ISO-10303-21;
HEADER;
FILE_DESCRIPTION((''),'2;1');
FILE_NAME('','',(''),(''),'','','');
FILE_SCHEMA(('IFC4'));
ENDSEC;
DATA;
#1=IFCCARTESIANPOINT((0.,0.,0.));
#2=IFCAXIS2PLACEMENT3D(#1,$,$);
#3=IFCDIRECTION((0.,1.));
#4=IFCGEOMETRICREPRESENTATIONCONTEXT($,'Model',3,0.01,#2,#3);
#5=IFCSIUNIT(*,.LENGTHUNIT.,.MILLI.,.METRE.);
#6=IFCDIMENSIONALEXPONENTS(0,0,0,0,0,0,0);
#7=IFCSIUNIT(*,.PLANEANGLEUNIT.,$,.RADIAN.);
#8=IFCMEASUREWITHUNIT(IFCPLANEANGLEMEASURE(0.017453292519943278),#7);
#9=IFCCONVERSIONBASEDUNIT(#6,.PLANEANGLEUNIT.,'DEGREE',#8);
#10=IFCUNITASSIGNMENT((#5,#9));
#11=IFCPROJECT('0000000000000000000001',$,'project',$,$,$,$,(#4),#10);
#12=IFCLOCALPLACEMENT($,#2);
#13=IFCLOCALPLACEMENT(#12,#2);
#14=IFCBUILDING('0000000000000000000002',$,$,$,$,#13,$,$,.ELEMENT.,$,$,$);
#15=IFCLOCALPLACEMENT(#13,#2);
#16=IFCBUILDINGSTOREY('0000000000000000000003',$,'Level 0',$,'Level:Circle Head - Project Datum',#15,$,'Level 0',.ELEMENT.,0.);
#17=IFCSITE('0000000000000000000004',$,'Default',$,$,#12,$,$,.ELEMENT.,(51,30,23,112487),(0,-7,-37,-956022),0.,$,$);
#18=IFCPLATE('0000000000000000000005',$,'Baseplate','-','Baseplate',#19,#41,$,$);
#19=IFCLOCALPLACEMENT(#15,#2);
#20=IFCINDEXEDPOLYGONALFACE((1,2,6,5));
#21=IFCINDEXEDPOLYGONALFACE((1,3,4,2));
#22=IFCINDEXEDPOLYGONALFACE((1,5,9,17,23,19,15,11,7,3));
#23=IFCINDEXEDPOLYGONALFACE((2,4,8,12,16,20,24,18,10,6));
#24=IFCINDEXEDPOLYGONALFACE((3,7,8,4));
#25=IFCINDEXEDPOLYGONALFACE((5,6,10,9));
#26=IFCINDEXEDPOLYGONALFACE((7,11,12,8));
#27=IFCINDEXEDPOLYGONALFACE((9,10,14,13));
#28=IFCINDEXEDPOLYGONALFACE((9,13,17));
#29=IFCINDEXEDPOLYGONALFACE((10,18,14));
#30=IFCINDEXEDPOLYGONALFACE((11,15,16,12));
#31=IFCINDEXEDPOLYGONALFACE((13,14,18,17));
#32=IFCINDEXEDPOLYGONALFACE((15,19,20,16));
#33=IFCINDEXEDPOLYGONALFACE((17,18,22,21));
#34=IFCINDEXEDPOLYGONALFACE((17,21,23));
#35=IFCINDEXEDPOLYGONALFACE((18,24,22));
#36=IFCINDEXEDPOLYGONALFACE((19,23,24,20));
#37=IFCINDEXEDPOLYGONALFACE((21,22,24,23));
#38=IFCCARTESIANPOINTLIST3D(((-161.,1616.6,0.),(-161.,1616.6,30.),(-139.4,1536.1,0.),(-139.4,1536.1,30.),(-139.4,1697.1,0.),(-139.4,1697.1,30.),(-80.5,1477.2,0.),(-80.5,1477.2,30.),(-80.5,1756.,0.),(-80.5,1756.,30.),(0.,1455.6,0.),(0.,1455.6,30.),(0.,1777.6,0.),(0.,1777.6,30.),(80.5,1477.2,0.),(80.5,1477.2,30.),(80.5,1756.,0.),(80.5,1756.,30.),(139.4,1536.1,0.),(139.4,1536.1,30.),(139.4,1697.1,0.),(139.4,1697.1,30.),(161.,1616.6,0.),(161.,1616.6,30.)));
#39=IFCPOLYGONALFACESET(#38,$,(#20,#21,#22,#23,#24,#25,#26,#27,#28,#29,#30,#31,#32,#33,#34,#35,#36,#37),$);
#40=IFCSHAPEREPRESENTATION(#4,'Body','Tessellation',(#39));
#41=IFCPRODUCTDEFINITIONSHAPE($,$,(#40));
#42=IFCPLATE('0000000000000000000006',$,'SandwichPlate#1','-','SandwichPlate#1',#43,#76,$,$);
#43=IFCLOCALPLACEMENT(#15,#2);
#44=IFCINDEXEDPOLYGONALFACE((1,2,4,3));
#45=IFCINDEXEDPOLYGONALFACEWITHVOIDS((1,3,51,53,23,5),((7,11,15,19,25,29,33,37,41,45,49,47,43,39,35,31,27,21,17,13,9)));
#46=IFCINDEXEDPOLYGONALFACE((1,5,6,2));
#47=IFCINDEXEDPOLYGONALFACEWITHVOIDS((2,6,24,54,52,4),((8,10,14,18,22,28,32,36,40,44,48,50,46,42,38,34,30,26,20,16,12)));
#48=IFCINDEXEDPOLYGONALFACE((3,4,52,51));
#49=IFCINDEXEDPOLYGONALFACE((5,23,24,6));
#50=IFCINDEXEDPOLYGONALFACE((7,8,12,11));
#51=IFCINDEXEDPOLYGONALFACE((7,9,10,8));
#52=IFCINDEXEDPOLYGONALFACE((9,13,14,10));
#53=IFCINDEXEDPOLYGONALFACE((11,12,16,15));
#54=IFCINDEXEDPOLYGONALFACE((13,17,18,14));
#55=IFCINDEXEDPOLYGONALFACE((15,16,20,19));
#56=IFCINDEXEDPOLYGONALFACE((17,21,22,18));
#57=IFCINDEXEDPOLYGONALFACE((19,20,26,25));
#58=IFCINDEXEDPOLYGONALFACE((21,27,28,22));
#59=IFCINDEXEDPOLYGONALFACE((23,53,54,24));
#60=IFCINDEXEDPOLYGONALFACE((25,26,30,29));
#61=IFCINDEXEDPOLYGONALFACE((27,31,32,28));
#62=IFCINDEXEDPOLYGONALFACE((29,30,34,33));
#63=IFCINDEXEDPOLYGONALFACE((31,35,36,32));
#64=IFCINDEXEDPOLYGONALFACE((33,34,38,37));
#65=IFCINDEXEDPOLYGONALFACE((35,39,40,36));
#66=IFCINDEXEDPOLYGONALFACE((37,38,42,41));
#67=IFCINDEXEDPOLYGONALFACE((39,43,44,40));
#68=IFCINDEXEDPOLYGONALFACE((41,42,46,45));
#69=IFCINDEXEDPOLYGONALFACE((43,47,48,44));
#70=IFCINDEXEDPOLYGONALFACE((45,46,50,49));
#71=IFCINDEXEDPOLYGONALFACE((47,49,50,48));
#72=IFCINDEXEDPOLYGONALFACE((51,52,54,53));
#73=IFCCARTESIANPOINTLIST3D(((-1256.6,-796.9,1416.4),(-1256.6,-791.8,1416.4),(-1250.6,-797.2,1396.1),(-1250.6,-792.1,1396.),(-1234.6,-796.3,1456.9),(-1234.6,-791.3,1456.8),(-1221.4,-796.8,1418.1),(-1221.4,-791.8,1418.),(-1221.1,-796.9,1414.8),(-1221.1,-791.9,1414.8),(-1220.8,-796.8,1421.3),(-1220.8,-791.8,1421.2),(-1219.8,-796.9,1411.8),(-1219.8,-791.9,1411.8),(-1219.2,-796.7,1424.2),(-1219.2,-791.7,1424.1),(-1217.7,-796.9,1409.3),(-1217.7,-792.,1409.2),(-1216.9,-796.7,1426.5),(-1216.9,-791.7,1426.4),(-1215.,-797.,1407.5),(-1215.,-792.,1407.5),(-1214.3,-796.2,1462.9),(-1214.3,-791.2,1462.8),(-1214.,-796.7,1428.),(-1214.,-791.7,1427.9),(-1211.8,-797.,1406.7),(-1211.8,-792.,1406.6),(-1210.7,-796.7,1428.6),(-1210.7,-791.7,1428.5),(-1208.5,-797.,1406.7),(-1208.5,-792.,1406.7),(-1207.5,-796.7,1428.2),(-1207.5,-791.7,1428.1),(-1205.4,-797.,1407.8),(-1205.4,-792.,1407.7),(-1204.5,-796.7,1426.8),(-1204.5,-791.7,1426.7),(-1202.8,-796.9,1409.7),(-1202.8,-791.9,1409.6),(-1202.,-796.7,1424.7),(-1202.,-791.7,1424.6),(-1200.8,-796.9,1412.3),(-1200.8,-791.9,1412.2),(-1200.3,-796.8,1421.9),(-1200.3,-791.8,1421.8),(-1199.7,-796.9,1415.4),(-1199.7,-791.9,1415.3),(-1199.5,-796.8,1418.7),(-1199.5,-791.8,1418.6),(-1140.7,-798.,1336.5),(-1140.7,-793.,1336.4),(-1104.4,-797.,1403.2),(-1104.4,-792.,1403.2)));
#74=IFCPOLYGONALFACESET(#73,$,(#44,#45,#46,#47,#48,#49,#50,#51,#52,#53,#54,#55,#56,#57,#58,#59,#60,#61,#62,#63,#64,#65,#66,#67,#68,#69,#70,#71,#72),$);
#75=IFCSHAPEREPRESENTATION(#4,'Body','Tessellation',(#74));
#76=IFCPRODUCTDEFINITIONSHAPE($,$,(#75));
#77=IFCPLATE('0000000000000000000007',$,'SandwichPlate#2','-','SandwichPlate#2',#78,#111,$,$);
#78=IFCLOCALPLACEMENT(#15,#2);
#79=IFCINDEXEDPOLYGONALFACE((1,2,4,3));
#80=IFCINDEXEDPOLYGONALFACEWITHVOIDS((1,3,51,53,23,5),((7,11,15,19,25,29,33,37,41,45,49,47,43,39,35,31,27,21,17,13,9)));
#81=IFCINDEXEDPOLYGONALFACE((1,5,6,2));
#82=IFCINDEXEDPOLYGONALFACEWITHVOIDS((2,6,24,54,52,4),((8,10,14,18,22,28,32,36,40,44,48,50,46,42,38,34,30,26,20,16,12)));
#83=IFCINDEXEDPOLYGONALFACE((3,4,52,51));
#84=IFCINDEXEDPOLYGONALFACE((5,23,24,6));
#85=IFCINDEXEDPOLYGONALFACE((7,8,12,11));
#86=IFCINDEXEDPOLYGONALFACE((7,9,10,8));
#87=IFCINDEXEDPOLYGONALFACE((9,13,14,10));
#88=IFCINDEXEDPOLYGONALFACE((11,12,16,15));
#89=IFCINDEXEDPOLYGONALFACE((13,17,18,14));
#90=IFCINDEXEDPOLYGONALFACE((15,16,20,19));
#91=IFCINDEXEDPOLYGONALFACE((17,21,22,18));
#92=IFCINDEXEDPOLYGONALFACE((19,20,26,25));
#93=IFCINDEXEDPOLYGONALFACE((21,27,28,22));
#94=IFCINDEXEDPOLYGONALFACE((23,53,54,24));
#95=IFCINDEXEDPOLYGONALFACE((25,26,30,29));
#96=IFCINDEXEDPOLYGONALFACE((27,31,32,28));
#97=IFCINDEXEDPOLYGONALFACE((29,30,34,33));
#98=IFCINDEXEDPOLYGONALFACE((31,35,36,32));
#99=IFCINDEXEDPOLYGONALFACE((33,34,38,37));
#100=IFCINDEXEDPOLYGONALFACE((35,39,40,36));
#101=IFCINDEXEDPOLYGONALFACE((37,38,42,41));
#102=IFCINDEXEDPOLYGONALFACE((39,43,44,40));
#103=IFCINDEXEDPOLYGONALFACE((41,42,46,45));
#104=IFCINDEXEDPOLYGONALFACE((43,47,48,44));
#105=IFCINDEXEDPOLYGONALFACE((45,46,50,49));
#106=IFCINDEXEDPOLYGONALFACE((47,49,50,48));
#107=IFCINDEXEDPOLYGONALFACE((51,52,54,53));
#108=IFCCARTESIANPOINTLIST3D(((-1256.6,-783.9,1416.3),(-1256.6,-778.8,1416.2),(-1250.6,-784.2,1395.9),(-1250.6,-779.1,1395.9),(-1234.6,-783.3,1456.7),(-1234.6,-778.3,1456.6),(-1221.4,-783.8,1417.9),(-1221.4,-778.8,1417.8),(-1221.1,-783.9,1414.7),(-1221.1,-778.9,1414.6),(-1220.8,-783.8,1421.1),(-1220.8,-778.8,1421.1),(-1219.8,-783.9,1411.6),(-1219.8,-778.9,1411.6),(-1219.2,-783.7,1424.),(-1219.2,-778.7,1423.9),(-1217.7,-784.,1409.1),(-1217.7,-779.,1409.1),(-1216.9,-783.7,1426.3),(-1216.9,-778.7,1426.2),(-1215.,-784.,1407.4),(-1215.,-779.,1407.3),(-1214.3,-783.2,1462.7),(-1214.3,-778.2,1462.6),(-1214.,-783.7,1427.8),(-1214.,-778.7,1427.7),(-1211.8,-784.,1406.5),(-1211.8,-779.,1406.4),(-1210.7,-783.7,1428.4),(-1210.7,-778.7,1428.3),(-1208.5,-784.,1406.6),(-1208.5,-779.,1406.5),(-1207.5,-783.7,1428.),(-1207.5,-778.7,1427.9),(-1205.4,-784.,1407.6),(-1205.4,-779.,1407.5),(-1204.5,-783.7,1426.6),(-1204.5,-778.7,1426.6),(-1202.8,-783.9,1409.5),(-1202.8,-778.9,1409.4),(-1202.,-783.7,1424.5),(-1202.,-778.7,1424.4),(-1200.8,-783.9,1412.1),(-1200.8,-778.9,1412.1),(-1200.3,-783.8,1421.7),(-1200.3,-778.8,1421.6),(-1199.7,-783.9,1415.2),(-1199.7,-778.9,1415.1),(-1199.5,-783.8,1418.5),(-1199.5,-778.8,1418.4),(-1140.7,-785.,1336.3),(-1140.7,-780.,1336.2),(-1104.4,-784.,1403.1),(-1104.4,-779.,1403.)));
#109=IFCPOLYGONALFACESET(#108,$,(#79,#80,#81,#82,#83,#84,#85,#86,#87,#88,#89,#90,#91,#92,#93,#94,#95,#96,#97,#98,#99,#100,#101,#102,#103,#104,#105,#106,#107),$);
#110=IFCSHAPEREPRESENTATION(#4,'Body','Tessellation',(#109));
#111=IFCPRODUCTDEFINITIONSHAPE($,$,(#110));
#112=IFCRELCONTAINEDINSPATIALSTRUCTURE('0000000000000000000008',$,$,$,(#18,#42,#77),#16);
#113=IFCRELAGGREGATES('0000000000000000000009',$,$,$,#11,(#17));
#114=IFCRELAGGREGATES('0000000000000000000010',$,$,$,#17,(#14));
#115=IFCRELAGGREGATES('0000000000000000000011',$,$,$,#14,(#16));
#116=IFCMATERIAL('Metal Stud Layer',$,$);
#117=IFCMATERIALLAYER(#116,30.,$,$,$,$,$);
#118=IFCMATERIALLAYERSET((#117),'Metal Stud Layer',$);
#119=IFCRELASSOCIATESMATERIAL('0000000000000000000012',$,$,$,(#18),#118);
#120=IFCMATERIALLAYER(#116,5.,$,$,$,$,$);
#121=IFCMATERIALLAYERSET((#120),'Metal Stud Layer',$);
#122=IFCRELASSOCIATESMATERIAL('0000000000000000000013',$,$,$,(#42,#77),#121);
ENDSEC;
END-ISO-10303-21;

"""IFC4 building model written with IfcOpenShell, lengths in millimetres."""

from ifc_helpers import new_model, entity, si_unit, converted_unit, point, direction, frame, frame_2d, origin, origin_with_axes, origin_2d_with_axis, place, context, project, spatial, polyline, circle_curve, line_curve, trimmed, segment, composite_curve, circle, outline, extrude, material, layer, layer_set, element, save


model = new_model("IFC4")

# Units and contexts
model_context = context("Model", 3, precision=0.01, world=origin(), true_north=direction((0.0, 1.0)))
ifc_project = project(units=[si_unit("LENGTHUNIT", "METRE", prefix="MILLI"), converted_unit("PLANEANGLEUNIT", "DEGREE", entity("IfcPlaneAngleMeasure", 0.017453292519943278), si_unit("PLANEANGLEUNIT", "RADIAN"), dimensions=[0, 0, 0, 0, 0, 0, 0])], contexts=[model_context])

# Site, building, storey
site_placement = place(None, origin())
site = spatial("IfcSite", under=ifc_project, at=site_placement, Name="Default", CompositionType="ELEMENT", RefLatitude=(51, 30, 23, 112487), RefLongitude=(0, -7, -37, -956022), RefElevation=0.0)
building_placement = place(site_placement, origin())
building = spatial("IfcBuilding", under=site, at=building_placement, CompositionType="ELEMENT")
storey_placement = place(building_placement, origin())
storey = spatial("IfcBuildingStorey", under=building, at=storey_placement, Name="Level 0", ObjectType="Level:Circle Head - Project Datum", LongName="Level 0", CompositionType="ELEMENT", Elevation=0.0)

# Plates, openings
ifc_material_1 = material(Name="Metal Stud Layer")
ifc_layer_1 = layer(ifc_material_1, 30.0)
ifc_layer_set_1 = layer_set([ifc_layer_1], Name="Metal Stud Layer")
plate_1_placement = place(storey_placement, frame((-161.0, 1616.6, 30.0), z_axis=(0.0, 0.0, -1.0), x_axis=(0.0, 1.0, 0.0)))
plate_1 = element("IfcPlate", 1, at=plate_1_placement, inside=storey, material=ifc_layer_set_1, Name="Baseplate", Description="-", ObjectType="Baseplate", context=model_context, shape_type="SweptSolid", body=[
    extrude(outline(polyline([(161.0, 0.0), (161.0, 322.0), (-161.0, 322.0), (-161.0, 0.0), (161.0, 0.0)])), origin_with_axes(), (0.0, 0.0, 1.0), 30.0),
])
opening_1_placement = place(plate_1_placement, frame((0.0, 0.0, 0.0), z_axis=(0.0, 0.0, 1.0), x_axis=(1.0, 0.0, 0.0)))
element("IfcOpeningElement", 2, at=opening_1_placement, cuts=plate_1, ObjectType="Opening", context=model_context, shape_type="SweptSolid", body=[
    extrude(outline(composite_curve([segment(trimmed(line_curve((161.0, 0.0), (0.0, 1.0), 161.0), [point((161.0, 0.0))], [point((161.0, 161.0))], True, "CARTESIAN"), True, "CONTINUOUS"), segment(trimmed(circle_curve(frame_2d((0.0, 161.0), x_axis=(-1.0, 0.0)), 161.0), [point((161.0, 161.0))], [point((0.0, 0.0))], False, "CARTESIAN"), True, "CONTINUOUS"), segment(trimmed(line_curve((0.0, 0.0), (1.0, 0.0), 161.0), [point((0.0, 0.0))], [point((161.0, 0.0))], True, "CARTESIAN"), True, "CONTINUOUS")], self_intersect="UNKNOWN")), origin(), (0.0, 0.0, 1.0), 30.0),
])
opening_2_placement = place(plate_1_placement, frame((0.0, 0.0, 0.0), z_axis=(0.0, 0.0, 1.0), x_axis=(1.0, 0.0, 0.0)))
element("IfcOpeningElement", 3, at=opening_2_placement, cuts=plate_1, ObjectType="Opening", context=model_context, shape_type="SweptSolid", body=[
    extrude(outline(composite_curve([segment(trimmed(line_curve((161.0, 322.0), (-1.0, 0.0), 161.0), [point((161.0, 322.0))], [point((0.0, 322.0))], True, "CARTESIAN"), True, "CONTINUOUS"), segment(trimmed(circle_curve(frame_2d((0.0, 161.0), x_axis=(-1.0, 0.0)), 161.0), [point((0.0, 322.0))], [point((161.0, 161.0))], False, "CARTESIAN"), True, "CONTINUOUS"), segment(trimmed(line_curve((161.0, 161.0), (0.0, 1.0), 161.0), [point((161.0, 161.0))], [point((161.0, 322.0))], True, "CARTESIAN"), True, "CONTINUOUS")], self_intersect="UNKNOWN")), origin(), (0.0, 0.0, 1.0), 30.0),
])
opening_3_placement = place(plate_1_placement, frame((0.0, 0.0, 0.0), z_axis=(0.0, 0.0, 1.0), x_axis=(1.0, 0.0, 0.0)))
element("IfcOpeningElement", 4, at=opening_3_placement, cuts=plate_1, ObjectType="Opening", context=model_context, shape_type="SweptSolid", body=[
    extrude(outline(composite_curve([segment(trimmed(line_curve((-161.0, 322.0), (0.0, -1.0), 161.0), [point((-161.0, 322.0))], [point((-161.0, 161.0))], True, "CARTESIAN"), True, "CONTINUOUS"), segment(trimmed(circle_curve(frame_2d((0.0, 161.0), x_axis=(-1.0, 0.0)), 161.0), [point((-161.0, 161.0))], [point((0.0, 322.0))], False, "CARTESIAN"), True, "CONTINUOUS"), segment(trimmed(line_curve((0.0, 322.0), (-1.0, 0.0), 161.0), [point((0.0, 322.0))], [point((-161.0, 322.0))], True, "CARTESIAN"), True, "CONTINUOUS")], self_intersect="UNKNOWN")), origin(), (0.0, 0.0, 1.0), 30.0),
])
opening_4_placement = place(plate_1_placement, frame((0.0, 0.0, 0.0), z_axis=(0.0, 0.0, 1.0), x_axis=(1.0, 0.0, 0.0)))
element("IfcOpeningElement", 5, at=opening_4_placement, cuts=plate_1, ObjectType="Opening", context=model_context, shape_type="SweptSolid", body=[
    extrude(outline(composite_curve([segment(trimmed(line_curve((-161.0, 0.0), (1.0, 0.0), 161.0), [point((-161.0, 0.0))], [point((0.0, 0.0))], True, "CARTESIAN"), True, "CONTINUOUS"), segment(trimmed(circle_curve(frame_2d((0.0, 161.0), x_axis=(-1.0, 0.0)), 161.0), [point((0.0, 0.0))], [point((-161.0, 161.0))], False, "CARTESIAN"), True, "CONTINUOUS"), segment(trimmed(line_curve((-161.0, 161.0), (0.0, -1.0), 161.0), [point((-161.0, 161.0))], [point((-161.0, 0.0))], True, "CARTESIAN"), True, "CONTINUOUS")], self_intersect="UNKNOWN")), origin(), (0.0, 0.0, 1.0), 30.0),
])
ifc_layer_2 = layer(ifc_material_1, 5.0)
ifc_layer_set_2 = layer_set([ifc_layer_2], Name="Metal Stud Layer")
plate_2_placement = place(storey_placement, frame((-1263.7, -797.0, 1403.3), z_axis=(0.0, 0.999896, -0.014432), x_axis=(0.477218, 0.012683, 0.878693)))
plate_2 = element("IfcPlate", 6, at=plate_2_placement, inside=storey, material=ifc_layer_set_2, Name="SandwichPlate#1", Description="-", ObjectType="SandwichPlate#1", context=model_context, shape_type="SweptSolid", body=[
    extrude(outline(polyline([(0.0, 0.0), (76.0, 0.0), (76.0, 140.0), (0.0, 140.0), (0.0, 0.0)])), origin_with_axes(), (0.0, 0.0, 1.0), 5.0),
])
opening_5_placement = place(plate_2_placement, frame((0.0, 0.0, 0.0), z_axis=(0.0, 0.0, 1.0), x_axis=(1.0, 0.0, 0.0)))
element("IfcOpeningElement", 7, at=opening_5_placement, cuts=plate_2, ObjectType="Opening", context=model_context, shape_type="SweptSolid", body=[
    extrude(outline(polyline([(0.0, 0.0), (15.0, 0.0), (0.0, 15.0), (0.0, 0.0)])), origin(), (0.0, 0.0, 1.0), 5.0),
])
opening_6_placement = place(plate_2_placement, frame((0.0, 0.0, 0.0), z_axis=(0.0, 0.0, 1.0), x_axis=(1.0, 0.0, 0.0)))
element("IfcOpeningElement", 8, at=opening_6_placement, cuts=plate_2, ObjectType="Opening", context=model_context, shape_type="SweptSolid", body=[
    extrude(outline(polyline([(76.0, 0.0), (76.0, 15.0), (61.0, 0.0), (76.0, 0.0)])), origin(), (0.0, 0.0, 1.0), 5.0),
])
opening_7_placement = place(plate_2_placement, frame((38.0, 40.0, -0.5), z_axis=(0.0, 0.0, 1.0), x_axis=(0.0, 1.0, 0.0)))
element("IfcOpeningElement", 9, at=opening_7_placement, cuts=plate_2, ObjectType="Opening", context=model_context, shape_type="SweptSolid", body=[
    extrude(circle(Radius=11.0, at=origin_2d_with_axis()), origin(), (0.0, 0.0, 1.0), 6.0),
])
plate_3_placement = place(storey_placement, frame((-1263.7, -784.0, 1403.1), z_axis=(0.0, 0.999896, -0.014432), x_axis=(0.477218, 0.012683, 0.878693)))
plate_3 = element("IfcPlate", 10, at=plate_3_placement, inside=storey, material=ifc_layer_set_2, Name="SandwichPlate#2", Description="-", ObjectType="SandwichPlate#2", context=model_context, shape_type="SweptSolid", body=[
    extrude(outline(polyline([(0.0, 0.0), (76.0, 0.0), (76.0, 140.0), (0.0, 140.0), (0.0, 0.0)])), origin_with_axes(), (0.0, 0.0, 1.0), 5.0),
])
opening_8_placement = place(plate_3_placement, frame((0.0, 0.0, 0.0), z_axis=(0.0, 0.0, 1.0), x_axis=(1.0, 0.0, 0.0)))
element("IfcOpeningElement", 11, at=opening_8_placement, cuts=plate_3, ObjectType="Opening", context=model_context, shape_type="SweptSolid", body=[
    extrude(outline(polyline([(0.0, 0.0), (15.0, 0.0), (0.0, 15.0), (0.0, 0.0)])), origin(), (0.0, 0.0, 1.0), 5.0),
])
opening_9_placement = place(plate_3_placement, frame((0.0, 0.0, 0.0), z_axis=(0.0, 0.0, 1.0), x_axis=(1.0, 0.0, 0.0)))
element("IfcOpeningElement", 12, at=opening_9_placement, cuts=plate_3, ObjectType="Opening", context=model_context, shape_type="SweptSolid", body=[
    extrude(outline(polyline([(76.0, 0.0), (76.0, 15.0), (61.0, 0.0), (76.0, 0.0)])), origin(), (0.0, 0.0, 1.0), 5.0),
])
opening_10_placement = place(plate_3_placement, frame((38.0, 40.0, -0.5), z_axis=(0.0, 0.0, 1.0), x_axis=(0.0, 1.0, 0.0)))
element("IfcOpeningElement", 13, at=opening_10_placement, cuts=plate_3, ObjectType="Opening", context=model_context, shape_type="SweptSolid", body=[
    extrude(circle(Radius=11.0, at=origin_2d_with_axis()), origin(), (0.0, 0.0, 1.0), 6.0),
])

save(model, "model.ifc")
